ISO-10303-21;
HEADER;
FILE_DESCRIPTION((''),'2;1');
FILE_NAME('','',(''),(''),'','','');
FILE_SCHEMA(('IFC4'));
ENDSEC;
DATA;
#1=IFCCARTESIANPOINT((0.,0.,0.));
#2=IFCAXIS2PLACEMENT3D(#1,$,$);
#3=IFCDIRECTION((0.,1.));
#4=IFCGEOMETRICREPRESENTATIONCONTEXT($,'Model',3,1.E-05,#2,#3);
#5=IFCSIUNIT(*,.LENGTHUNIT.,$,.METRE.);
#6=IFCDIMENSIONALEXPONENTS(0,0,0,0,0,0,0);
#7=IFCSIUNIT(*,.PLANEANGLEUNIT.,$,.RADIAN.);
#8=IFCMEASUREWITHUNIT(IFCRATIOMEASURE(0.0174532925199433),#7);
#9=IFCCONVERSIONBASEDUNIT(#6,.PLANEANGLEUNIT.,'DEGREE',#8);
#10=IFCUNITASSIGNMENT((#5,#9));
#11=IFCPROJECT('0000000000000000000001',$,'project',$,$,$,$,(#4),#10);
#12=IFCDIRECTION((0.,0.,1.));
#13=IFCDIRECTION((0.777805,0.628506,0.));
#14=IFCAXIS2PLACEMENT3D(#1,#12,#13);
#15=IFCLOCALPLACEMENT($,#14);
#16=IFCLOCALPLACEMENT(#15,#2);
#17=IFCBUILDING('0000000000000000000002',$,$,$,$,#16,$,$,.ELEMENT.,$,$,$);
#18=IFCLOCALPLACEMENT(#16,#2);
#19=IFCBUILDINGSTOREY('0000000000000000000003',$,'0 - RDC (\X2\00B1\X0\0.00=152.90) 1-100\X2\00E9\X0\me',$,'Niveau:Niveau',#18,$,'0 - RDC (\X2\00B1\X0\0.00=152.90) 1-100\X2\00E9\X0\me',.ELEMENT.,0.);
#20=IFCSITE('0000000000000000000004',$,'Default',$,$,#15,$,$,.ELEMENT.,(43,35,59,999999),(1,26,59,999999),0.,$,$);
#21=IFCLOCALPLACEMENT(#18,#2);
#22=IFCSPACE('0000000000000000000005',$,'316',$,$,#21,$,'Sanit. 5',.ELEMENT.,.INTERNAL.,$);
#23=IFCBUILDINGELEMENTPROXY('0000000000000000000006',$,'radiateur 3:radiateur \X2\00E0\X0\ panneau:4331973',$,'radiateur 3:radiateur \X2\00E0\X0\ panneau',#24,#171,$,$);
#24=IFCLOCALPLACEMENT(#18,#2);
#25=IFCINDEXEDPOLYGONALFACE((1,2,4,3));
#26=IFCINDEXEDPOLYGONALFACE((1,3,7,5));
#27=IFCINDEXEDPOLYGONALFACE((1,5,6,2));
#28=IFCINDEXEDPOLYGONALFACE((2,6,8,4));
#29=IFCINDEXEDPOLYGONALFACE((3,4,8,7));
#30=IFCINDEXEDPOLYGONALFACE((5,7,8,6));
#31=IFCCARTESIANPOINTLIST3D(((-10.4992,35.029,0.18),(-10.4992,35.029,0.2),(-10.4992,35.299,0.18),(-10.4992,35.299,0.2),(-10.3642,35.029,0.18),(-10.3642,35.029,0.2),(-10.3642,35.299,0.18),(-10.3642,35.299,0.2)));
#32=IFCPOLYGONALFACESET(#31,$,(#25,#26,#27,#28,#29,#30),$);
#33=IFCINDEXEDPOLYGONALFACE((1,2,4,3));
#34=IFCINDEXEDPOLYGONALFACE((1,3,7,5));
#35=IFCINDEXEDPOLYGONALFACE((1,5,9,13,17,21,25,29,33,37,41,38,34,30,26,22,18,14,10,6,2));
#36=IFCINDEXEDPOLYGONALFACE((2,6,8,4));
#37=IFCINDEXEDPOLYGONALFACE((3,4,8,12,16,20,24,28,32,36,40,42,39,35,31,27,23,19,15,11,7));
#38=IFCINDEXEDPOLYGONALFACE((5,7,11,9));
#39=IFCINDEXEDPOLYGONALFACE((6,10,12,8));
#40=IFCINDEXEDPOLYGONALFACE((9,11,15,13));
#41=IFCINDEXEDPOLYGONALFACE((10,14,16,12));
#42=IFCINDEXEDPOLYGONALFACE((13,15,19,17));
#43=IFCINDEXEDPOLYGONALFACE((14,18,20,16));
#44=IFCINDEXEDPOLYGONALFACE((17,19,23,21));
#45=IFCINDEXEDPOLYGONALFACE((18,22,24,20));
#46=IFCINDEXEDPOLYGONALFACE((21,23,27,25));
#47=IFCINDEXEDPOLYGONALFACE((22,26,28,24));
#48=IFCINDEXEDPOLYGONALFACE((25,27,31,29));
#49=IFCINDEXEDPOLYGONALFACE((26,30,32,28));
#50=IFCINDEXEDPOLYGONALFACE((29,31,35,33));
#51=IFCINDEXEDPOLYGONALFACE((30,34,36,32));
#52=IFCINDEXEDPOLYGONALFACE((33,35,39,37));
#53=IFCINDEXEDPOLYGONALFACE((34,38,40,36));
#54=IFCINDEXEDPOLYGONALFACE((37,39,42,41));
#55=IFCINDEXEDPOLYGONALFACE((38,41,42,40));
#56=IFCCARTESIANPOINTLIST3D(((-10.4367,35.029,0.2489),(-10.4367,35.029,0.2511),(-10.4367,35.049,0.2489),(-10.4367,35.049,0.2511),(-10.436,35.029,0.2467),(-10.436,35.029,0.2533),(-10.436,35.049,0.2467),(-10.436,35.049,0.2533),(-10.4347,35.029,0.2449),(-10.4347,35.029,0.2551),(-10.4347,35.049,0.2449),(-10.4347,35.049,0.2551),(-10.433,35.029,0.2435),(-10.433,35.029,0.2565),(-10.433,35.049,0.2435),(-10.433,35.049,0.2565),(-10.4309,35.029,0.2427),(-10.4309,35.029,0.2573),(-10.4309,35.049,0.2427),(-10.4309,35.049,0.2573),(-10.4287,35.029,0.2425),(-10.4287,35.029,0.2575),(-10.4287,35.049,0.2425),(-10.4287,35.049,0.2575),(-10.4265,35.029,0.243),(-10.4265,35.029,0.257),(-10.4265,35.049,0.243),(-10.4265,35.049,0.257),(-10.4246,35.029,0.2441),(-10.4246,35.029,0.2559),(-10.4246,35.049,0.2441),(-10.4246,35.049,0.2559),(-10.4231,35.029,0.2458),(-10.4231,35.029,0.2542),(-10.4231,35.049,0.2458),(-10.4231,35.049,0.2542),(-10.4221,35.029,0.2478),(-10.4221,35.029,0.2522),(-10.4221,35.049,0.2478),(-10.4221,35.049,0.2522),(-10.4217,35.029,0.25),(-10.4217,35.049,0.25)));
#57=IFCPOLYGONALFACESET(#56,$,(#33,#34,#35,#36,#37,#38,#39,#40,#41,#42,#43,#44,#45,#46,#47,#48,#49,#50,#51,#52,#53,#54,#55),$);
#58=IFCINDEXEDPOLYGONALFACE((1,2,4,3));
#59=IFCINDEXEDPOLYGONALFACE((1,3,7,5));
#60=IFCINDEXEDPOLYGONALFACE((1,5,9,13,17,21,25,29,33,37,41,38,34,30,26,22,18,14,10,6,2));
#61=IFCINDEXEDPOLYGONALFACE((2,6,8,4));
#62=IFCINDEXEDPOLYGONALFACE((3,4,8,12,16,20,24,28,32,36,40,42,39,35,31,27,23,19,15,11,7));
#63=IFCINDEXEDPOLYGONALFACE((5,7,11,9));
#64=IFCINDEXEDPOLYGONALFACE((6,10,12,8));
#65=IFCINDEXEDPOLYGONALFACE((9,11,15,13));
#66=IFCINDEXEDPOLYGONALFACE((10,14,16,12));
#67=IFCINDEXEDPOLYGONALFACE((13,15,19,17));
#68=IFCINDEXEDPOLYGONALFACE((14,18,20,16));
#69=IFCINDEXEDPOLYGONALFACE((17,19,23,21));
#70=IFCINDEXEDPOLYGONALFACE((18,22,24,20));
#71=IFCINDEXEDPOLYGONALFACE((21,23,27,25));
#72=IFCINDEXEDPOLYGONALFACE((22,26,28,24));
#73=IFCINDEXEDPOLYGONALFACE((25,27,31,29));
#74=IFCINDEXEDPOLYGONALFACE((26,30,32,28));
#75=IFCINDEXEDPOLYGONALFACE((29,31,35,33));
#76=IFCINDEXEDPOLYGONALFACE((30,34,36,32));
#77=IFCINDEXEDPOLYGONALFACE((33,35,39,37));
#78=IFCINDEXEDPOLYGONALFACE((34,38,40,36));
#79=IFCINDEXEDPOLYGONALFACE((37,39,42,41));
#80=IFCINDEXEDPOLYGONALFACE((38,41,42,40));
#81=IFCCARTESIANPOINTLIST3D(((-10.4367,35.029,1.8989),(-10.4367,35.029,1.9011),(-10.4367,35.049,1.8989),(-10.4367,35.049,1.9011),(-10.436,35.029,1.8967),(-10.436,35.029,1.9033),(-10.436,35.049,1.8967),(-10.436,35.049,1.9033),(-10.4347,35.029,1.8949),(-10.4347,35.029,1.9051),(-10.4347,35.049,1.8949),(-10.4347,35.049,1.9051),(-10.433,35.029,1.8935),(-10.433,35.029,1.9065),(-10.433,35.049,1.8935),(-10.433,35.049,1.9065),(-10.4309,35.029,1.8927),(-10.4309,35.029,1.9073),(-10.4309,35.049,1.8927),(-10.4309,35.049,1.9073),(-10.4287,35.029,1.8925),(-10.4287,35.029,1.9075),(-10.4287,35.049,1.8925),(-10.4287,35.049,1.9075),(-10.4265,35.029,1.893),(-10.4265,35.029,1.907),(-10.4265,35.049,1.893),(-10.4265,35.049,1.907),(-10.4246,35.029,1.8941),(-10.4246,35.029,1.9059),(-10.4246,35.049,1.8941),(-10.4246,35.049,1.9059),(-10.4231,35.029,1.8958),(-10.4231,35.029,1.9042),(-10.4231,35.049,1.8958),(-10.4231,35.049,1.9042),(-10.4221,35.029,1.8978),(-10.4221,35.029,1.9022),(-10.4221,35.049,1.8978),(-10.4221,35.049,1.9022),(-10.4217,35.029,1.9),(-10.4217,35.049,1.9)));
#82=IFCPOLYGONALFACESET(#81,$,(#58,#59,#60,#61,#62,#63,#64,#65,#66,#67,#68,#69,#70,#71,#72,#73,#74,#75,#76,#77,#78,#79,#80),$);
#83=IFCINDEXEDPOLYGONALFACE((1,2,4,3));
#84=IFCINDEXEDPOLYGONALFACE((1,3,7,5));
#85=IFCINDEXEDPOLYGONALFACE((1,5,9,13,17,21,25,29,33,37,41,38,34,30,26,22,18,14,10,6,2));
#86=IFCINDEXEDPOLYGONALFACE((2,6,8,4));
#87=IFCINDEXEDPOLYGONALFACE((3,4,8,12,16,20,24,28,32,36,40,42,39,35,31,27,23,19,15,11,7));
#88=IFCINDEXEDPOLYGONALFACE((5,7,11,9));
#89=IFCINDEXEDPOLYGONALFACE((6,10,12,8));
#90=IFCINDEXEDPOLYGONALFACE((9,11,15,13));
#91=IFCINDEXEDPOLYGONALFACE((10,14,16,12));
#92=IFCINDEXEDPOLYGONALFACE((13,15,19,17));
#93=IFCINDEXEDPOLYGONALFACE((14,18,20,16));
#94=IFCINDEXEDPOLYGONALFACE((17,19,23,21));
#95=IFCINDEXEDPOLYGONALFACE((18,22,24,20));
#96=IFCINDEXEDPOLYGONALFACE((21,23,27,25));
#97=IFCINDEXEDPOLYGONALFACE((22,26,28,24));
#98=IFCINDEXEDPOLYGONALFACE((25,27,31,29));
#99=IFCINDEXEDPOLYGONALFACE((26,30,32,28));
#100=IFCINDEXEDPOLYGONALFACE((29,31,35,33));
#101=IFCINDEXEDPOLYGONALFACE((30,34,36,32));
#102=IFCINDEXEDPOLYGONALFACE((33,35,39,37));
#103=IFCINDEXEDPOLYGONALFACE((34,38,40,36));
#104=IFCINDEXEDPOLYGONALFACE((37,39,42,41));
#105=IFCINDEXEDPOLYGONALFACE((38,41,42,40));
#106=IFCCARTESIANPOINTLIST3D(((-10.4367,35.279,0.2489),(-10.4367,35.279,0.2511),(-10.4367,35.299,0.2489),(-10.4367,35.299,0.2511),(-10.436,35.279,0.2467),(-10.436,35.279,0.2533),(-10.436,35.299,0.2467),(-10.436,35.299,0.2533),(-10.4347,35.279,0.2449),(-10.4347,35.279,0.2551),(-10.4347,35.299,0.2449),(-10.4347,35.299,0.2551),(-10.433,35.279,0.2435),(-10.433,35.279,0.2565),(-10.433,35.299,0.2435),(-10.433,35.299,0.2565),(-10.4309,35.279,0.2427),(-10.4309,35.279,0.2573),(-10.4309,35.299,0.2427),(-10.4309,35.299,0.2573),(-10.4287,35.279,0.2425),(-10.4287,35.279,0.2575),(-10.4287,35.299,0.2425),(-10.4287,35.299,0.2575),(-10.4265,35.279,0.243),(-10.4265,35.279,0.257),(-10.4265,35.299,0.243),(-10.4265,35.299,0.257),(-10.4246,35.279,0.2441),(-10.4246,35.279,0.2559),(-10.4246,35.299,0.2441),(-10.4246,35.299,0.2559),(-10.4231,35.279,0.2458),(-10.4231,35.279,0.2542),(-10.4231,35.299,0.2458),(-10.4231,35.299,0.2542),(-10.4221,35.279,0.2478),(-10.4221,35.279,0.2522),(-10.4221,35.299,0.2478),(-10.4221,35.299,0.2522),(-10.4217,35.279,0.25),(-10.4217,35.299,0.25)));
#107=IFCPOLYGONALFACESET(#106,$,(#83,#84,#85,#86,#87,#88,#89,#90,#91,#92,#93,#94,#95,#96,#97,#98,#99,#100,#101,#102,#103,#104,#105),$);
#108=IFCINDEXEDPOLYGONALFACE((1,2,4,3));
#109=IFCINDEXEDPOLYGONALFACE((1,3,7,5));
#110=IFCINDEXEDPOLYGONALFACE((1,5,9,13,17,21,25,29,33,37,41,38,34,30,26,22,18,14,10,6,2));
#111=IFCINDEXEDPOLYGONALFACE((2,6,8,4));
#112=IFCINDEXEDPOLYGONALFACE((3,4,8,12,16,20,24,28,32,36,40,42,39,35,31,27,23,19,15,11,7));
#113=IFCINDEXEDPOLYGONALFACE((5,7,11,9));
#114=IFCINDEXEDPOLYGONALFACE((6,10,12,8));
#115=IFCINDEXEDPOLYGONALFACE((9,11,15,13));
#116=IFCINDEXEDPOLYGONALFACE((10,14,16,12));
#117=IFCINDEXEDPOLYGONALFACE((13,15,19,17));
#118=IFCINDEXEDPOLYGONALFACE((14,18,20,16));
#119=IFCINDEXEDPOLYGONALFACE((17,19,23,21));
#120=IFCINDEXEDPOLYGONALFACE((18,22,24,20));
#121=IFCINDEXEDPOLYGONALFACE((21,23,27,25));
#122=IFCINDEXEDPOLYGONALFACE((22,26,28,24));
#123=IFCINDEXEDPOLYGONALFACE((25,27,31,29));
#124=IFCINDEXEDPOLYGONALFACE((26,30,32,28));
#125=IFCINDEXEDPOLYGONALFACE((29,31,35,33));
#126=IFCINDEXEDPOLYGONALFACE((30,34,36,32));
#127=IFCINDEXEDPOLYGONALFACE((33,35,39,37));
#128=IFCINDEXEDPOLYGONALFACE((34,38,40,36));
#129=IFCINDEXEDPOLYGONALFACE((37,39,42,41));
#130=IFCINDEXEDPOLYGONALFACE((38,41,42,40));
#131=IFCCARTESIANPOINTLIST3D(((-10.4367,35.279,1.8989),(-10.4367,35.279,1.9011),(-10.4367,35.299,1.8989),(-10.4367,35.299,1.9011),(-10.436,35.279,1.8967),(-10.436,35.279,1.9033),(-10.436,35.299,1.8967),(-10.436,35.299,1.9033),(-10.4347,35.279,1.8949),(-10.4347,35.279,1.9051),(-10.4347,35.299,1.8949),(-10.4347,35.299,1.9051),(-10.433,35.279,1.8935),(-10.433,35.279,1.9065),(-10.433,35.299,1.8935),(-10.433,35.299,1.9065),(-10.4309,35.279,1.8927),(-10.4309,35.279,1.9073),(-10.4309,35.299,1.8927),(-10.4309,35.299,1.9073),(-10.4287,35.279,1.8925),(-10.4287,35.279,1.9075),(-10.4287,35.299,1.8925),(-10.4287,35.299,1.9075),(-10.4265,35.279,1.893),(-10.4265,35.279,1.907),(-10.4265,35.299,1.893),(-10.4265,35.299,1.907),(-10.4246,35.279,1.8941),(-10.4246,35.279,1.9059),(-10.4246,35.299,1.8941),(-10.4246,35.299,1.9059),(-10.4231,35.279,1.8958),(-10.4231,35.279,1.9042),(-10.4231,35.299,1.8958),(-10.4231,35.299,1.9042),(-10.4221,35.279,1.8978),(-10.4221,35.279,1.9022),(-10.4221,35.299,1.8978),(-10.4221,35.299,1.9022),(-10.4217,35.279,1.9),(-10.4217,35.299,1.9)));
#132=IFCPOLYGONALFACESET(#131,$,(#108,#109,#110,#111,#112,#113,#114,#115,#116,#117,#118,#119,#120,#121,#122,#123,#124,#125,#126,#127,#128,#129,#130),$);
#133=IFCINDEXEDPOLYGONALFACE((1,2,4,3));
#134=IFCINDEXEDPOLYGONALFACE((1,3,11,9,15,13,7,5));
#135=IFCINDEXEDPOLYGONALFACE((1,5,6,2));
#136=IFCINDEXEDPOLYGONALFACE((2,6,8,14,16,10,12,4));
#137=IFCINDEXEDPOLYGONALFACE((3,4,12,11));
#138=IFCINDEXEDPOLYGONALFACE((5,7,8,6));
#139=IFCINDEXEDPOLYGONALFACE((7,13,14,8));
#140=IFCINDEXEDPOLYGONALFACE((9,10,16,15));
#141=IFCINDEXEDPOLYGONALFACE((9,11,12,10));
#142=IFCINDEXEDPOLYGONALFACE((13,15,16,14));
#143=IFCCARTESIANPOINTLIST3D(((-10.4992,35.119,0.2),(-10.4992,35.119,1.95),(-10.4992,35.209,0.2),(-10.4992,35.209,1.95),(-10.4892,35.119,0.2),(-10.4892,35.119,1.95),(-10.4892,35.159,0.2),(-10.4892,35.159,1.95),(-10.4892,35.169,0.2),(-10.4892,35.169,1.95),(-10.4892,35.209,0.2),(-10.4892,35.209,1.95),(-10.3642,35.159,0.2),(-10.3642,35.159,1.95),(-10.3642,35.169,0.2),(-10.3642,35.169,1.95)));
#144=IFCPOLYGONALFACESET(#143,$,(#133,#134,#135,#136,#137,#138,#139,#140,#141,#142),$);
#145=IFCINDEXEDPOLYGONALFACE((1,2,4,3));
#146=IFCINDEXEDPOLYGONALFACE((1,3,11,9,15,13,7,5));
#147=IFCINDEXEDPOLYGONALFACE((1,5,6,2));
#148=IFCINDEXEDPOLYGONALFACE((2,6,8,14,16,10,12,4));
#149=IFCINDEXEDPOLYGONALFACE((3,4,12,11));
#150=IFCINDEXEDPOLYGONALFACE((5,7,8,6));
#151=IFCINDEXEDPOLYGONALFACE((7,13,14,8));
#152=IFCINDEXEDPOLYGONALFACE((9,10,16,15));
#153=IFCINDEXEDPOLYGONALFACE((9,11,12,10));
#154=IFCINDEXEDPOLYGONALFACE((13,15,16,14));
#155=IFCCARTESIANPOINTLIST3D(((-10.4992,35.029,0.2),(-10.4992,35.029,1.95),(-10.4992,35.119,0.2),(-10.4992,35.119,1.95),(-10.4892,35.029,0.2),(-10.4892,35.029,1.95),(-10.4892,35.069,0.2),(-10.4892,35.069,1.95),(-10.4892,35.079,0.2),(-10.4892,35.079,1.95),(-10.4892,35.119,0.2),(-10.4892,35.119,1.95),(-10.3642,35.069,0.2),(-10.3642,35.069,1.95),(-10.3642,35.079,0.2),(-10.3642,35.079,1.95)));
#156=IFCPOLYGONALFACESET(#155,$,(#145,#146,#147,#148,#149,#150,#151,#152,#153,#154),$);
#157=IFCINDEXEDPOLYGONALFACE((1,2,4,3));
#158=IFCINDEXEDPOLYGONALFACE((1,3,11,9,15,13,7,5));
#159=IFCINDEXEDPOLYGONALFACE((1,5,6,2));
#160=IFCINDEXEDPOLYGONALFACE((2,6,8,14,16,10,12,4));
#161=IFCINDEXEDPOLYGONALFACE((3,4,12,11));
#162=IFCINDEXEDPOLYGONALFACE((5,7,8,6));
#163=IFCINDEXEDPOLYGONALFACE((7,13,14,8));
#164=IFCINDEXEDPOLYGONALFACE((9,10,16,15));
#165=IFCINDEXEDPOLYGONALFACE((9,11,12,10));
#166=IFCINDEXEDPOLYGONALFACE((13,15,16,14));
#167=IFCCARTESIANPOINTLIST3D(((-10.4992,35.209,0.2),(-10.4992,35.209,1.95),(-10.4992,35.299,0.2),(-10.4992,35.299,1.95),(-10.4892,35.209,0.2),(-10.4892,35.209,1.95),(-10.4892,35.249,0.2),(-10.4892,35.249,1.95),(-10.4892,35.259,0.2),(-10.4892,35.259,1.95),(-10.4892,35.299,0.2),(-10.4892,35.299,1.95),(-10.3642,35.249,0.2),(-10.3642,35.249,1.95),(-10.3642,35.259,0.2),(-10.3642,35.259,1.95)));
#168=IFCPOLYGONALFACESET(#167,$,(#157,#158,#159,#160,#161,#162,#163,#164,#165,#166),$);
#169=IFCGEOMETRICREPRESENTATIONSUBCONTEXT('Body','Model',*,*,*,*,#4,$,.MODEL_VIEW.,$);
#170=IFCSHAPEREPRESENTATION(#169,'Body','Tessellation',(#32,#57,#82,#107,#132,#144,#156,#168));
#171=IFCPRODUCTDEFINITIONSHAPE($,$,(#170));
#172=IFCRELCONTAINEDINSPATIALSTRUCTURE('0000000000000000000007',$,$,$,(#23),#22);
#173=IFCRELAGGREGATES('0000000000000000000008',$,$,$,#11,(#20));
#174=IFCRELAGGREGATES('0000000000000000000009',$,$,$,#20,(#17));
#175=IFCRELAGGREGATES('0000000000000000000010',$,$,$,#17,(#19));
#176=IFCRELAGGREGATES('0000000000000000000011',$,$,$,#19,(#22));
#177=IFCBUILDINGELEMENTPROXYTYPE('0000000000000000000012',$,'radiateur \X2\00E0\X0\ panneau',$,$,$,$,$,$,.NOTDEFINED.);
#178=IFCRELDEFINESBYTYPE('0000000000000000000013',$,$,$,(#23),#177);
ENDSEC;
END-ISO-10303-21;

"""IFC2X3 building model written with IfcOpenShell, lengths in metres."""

from ifc_helpers import new_model, entity, si_unit, converted_unit, direction, frame, frame_2d, origin, origin_2d_with_axis, place, context, subcontext, project, spatial, polyline, rectangle, circle, outline, extrude, source, transform, mapped, type_object, type_shapes, element, save


model = new_model("IFC2X3")

# Units and contexts
model_context = context("Model", 3, precision=1e-05, world=origin(), true_north=direction((0.0, 1.0)))
body_context = subcontext(model_context, "Body", "Model", "MODEL_VIEW")
ifc_project = project(units=[si_unit("LENGTHUNIT", "METRE"), converted_unit("PLANEANGLEUNIT", "DEGREE", entity("IfcRatioMeasure", 0.0174532925199433), si_unit("PLANEANGLEUNIT", "RADIAN"), dimensions=[0, 0, 0, 0, 0, 0, 0])], contexts=[model_context])

# Site, building, storey
site_placement = place(None, frame((0.0, 0.0, 0.0), z_axis=(0.0, 0.0, 1.0), x_axis=(0.777805, 0.628506, 0.0)))
site = spatial("IfcSite", under=ifc_project, at=site_placement, Name="Default", CompositionType="ELEMENT", RefLatitude=(43, 35, 59, 999999), RefLongitude=(1, 26, 59, 999999), RefElevation=0.0)
building_placement = place(site_placement, origin())
building = spatial("IfcBuilding", under=site, at=building_placement, CompositionType="ELEMENT")
storey_placement = place(building_placement, origin())
storey = spatial("IfcBuildingStorey", under=building, at=storey_placement, Name="0 - RDC (±0.00=152.90) 1-100éme", ObjectType="Niveau:Niveau", LongName="0 - RDC (±0.00=152.90) 1-100éme", CompositionType="ELEMENT", Elevation=0.0)

# Shared definitions
space_1_placement = place(storey_placement, origin())
space_1 = spatial("IfcSpace", under=storey, at=space_1_placement, Name="316", LongName="Sanit. 5", CompositionType="ELEMENT", InteriorOrExteriorSpace="INTERNAL")

# Building element proxy
building_element_proxy_type = type_object("IfcBuildingElementProxyType", Name="radiateur à panneau", PredefinedType="NOTDEFINED")
shared_shape_1 = source(origin(), body_context, "Body", "SweptSolid", [
    extrude(rectangle(XDim=0.135, YDim=0.27, at=frame_2d((0.0, 0.0), x_axis=(1.0, 0.0))), frame((0.135, -0.0025, -0.02), z_axis=(0.0, 0.0, 1.0), x_axis=(0.0, -1.0, 0.0)), (0.0, 0.0, 1.0), 0.02),
    extrude(circle(Radius=0.0075, at=frame_2d((0.0, 0.0), x_axis=(1.0, 0.0))), frame((0.25, 0.0, 0.05), z_axis=(1.0, 0.0, 0.0), x_axis=(0.0, 1.0, 0.0)), (0.0, 0.0, 1.0), 0.02),
    extrude(circle(Radius=0.0075, at=frame_2d((0.0, 0.0), x_axis=(1.0, 0.0))), frame((0.25, 0.0, 1.7), z_axis=(1.0, 0.0, 0.0), x_axis=(0.0, 1.0, 0.0)), (0.0, 0.0, 1.0), 0.02),
    extrude(circle(Radius=0.0075, at=frame_2d((0.0, 0.0), x_axis=(1.0, 0.0))), frame((0.0, 0.0, 0.05), z_axis=(1.0, 0.0, 0.0), x_axis=(0.0, 1.0, 0.0)), (0.0, 0.0, 1.0), 0.02),
    extrude(circle(Radius=0.0075, at=origin_2d_with_axis()), frame((0.0, 0.0, 1.7), z_axis=(1.0, 0.0, 0.0), x_axis=(0.0, 1.0, 0.0)), (0.0, 0.0, 1.0), 0.02),
    extrude(outline(polyline([(-0.005, -0.0963), (0.005, -0.0963), (0.005, 0.0288), (0.045, 0.0288), (0.045, 0.0387), (-0.045, 0.0387), (-0.045, 0.0288), (-0.005, 0.0288), (-0.005, -0.0963)])), frame((0.135, -0.0313, 0.0), z_axis=(0.0, 0.0, 1.0), x_axis=(-1.0, 0.0, 0.0)), (0.0, 0.0, 1.0), 1.75),
    extrude(outline(polyline([(-0.005, -0.0963), (0.005, -0.0963), (0.005, 0.0288), (0.045, 0.0288), (0.045, 0.0387), (-0.045, 0.0387), (-0.045, 0.0288), (-0.005, 0.0288), (-0.005, -0.0963)])), frame((0.225, -0.0313, 0.0), z_axis=(0.0, 0.0, 1.0), x_axis=(-1.0, 0.0, 0.0)), (0.0, 0.0, 1.0), 1.75),
    extrude(outline(polyline([(-0.005, -0.0963), (0.005, -0.0963), (0.005, 0.0288), (0.045, 0.0288), (0.045, 0.0387), (-0.045, 0.0387), (-0.045, 0.0288), (-0.005, 0.0288), (-0.005, -0.0963)])), frame((0.045, -0.0313, 0.0), z_axis=(0.0, 0.0, 1.0), x_axis=(-1.0, 0.0, 0.0)), (0.0, 0.0, 1.0), 1.75),
])
type_shapes(building_element_proxy_type, [shared_shape_1])
proxy_1_placement = place(space_1_placement, frame((-10.4292, 35.299, 0.2), z_axis=(0.0, 0.0, 1.0), x_axis=(0.0, -1.0, 0.0)))
element("IfcBuildingElementProxy", 1, at=proxy_1_placement, inside=space_1, type_object=building_element_proxy_type, Name="radiateur 3:radiateur à panneau:4331973", ObjectType="radiateur 3:radiateur à panneau", context=body_context, shape_type="MappedRepresentation", body=[
    mapped(shared_shape_1, transform((0.0, 0.0, 0.0), scale=1.0)),
])

save(model, "model.ifc")
